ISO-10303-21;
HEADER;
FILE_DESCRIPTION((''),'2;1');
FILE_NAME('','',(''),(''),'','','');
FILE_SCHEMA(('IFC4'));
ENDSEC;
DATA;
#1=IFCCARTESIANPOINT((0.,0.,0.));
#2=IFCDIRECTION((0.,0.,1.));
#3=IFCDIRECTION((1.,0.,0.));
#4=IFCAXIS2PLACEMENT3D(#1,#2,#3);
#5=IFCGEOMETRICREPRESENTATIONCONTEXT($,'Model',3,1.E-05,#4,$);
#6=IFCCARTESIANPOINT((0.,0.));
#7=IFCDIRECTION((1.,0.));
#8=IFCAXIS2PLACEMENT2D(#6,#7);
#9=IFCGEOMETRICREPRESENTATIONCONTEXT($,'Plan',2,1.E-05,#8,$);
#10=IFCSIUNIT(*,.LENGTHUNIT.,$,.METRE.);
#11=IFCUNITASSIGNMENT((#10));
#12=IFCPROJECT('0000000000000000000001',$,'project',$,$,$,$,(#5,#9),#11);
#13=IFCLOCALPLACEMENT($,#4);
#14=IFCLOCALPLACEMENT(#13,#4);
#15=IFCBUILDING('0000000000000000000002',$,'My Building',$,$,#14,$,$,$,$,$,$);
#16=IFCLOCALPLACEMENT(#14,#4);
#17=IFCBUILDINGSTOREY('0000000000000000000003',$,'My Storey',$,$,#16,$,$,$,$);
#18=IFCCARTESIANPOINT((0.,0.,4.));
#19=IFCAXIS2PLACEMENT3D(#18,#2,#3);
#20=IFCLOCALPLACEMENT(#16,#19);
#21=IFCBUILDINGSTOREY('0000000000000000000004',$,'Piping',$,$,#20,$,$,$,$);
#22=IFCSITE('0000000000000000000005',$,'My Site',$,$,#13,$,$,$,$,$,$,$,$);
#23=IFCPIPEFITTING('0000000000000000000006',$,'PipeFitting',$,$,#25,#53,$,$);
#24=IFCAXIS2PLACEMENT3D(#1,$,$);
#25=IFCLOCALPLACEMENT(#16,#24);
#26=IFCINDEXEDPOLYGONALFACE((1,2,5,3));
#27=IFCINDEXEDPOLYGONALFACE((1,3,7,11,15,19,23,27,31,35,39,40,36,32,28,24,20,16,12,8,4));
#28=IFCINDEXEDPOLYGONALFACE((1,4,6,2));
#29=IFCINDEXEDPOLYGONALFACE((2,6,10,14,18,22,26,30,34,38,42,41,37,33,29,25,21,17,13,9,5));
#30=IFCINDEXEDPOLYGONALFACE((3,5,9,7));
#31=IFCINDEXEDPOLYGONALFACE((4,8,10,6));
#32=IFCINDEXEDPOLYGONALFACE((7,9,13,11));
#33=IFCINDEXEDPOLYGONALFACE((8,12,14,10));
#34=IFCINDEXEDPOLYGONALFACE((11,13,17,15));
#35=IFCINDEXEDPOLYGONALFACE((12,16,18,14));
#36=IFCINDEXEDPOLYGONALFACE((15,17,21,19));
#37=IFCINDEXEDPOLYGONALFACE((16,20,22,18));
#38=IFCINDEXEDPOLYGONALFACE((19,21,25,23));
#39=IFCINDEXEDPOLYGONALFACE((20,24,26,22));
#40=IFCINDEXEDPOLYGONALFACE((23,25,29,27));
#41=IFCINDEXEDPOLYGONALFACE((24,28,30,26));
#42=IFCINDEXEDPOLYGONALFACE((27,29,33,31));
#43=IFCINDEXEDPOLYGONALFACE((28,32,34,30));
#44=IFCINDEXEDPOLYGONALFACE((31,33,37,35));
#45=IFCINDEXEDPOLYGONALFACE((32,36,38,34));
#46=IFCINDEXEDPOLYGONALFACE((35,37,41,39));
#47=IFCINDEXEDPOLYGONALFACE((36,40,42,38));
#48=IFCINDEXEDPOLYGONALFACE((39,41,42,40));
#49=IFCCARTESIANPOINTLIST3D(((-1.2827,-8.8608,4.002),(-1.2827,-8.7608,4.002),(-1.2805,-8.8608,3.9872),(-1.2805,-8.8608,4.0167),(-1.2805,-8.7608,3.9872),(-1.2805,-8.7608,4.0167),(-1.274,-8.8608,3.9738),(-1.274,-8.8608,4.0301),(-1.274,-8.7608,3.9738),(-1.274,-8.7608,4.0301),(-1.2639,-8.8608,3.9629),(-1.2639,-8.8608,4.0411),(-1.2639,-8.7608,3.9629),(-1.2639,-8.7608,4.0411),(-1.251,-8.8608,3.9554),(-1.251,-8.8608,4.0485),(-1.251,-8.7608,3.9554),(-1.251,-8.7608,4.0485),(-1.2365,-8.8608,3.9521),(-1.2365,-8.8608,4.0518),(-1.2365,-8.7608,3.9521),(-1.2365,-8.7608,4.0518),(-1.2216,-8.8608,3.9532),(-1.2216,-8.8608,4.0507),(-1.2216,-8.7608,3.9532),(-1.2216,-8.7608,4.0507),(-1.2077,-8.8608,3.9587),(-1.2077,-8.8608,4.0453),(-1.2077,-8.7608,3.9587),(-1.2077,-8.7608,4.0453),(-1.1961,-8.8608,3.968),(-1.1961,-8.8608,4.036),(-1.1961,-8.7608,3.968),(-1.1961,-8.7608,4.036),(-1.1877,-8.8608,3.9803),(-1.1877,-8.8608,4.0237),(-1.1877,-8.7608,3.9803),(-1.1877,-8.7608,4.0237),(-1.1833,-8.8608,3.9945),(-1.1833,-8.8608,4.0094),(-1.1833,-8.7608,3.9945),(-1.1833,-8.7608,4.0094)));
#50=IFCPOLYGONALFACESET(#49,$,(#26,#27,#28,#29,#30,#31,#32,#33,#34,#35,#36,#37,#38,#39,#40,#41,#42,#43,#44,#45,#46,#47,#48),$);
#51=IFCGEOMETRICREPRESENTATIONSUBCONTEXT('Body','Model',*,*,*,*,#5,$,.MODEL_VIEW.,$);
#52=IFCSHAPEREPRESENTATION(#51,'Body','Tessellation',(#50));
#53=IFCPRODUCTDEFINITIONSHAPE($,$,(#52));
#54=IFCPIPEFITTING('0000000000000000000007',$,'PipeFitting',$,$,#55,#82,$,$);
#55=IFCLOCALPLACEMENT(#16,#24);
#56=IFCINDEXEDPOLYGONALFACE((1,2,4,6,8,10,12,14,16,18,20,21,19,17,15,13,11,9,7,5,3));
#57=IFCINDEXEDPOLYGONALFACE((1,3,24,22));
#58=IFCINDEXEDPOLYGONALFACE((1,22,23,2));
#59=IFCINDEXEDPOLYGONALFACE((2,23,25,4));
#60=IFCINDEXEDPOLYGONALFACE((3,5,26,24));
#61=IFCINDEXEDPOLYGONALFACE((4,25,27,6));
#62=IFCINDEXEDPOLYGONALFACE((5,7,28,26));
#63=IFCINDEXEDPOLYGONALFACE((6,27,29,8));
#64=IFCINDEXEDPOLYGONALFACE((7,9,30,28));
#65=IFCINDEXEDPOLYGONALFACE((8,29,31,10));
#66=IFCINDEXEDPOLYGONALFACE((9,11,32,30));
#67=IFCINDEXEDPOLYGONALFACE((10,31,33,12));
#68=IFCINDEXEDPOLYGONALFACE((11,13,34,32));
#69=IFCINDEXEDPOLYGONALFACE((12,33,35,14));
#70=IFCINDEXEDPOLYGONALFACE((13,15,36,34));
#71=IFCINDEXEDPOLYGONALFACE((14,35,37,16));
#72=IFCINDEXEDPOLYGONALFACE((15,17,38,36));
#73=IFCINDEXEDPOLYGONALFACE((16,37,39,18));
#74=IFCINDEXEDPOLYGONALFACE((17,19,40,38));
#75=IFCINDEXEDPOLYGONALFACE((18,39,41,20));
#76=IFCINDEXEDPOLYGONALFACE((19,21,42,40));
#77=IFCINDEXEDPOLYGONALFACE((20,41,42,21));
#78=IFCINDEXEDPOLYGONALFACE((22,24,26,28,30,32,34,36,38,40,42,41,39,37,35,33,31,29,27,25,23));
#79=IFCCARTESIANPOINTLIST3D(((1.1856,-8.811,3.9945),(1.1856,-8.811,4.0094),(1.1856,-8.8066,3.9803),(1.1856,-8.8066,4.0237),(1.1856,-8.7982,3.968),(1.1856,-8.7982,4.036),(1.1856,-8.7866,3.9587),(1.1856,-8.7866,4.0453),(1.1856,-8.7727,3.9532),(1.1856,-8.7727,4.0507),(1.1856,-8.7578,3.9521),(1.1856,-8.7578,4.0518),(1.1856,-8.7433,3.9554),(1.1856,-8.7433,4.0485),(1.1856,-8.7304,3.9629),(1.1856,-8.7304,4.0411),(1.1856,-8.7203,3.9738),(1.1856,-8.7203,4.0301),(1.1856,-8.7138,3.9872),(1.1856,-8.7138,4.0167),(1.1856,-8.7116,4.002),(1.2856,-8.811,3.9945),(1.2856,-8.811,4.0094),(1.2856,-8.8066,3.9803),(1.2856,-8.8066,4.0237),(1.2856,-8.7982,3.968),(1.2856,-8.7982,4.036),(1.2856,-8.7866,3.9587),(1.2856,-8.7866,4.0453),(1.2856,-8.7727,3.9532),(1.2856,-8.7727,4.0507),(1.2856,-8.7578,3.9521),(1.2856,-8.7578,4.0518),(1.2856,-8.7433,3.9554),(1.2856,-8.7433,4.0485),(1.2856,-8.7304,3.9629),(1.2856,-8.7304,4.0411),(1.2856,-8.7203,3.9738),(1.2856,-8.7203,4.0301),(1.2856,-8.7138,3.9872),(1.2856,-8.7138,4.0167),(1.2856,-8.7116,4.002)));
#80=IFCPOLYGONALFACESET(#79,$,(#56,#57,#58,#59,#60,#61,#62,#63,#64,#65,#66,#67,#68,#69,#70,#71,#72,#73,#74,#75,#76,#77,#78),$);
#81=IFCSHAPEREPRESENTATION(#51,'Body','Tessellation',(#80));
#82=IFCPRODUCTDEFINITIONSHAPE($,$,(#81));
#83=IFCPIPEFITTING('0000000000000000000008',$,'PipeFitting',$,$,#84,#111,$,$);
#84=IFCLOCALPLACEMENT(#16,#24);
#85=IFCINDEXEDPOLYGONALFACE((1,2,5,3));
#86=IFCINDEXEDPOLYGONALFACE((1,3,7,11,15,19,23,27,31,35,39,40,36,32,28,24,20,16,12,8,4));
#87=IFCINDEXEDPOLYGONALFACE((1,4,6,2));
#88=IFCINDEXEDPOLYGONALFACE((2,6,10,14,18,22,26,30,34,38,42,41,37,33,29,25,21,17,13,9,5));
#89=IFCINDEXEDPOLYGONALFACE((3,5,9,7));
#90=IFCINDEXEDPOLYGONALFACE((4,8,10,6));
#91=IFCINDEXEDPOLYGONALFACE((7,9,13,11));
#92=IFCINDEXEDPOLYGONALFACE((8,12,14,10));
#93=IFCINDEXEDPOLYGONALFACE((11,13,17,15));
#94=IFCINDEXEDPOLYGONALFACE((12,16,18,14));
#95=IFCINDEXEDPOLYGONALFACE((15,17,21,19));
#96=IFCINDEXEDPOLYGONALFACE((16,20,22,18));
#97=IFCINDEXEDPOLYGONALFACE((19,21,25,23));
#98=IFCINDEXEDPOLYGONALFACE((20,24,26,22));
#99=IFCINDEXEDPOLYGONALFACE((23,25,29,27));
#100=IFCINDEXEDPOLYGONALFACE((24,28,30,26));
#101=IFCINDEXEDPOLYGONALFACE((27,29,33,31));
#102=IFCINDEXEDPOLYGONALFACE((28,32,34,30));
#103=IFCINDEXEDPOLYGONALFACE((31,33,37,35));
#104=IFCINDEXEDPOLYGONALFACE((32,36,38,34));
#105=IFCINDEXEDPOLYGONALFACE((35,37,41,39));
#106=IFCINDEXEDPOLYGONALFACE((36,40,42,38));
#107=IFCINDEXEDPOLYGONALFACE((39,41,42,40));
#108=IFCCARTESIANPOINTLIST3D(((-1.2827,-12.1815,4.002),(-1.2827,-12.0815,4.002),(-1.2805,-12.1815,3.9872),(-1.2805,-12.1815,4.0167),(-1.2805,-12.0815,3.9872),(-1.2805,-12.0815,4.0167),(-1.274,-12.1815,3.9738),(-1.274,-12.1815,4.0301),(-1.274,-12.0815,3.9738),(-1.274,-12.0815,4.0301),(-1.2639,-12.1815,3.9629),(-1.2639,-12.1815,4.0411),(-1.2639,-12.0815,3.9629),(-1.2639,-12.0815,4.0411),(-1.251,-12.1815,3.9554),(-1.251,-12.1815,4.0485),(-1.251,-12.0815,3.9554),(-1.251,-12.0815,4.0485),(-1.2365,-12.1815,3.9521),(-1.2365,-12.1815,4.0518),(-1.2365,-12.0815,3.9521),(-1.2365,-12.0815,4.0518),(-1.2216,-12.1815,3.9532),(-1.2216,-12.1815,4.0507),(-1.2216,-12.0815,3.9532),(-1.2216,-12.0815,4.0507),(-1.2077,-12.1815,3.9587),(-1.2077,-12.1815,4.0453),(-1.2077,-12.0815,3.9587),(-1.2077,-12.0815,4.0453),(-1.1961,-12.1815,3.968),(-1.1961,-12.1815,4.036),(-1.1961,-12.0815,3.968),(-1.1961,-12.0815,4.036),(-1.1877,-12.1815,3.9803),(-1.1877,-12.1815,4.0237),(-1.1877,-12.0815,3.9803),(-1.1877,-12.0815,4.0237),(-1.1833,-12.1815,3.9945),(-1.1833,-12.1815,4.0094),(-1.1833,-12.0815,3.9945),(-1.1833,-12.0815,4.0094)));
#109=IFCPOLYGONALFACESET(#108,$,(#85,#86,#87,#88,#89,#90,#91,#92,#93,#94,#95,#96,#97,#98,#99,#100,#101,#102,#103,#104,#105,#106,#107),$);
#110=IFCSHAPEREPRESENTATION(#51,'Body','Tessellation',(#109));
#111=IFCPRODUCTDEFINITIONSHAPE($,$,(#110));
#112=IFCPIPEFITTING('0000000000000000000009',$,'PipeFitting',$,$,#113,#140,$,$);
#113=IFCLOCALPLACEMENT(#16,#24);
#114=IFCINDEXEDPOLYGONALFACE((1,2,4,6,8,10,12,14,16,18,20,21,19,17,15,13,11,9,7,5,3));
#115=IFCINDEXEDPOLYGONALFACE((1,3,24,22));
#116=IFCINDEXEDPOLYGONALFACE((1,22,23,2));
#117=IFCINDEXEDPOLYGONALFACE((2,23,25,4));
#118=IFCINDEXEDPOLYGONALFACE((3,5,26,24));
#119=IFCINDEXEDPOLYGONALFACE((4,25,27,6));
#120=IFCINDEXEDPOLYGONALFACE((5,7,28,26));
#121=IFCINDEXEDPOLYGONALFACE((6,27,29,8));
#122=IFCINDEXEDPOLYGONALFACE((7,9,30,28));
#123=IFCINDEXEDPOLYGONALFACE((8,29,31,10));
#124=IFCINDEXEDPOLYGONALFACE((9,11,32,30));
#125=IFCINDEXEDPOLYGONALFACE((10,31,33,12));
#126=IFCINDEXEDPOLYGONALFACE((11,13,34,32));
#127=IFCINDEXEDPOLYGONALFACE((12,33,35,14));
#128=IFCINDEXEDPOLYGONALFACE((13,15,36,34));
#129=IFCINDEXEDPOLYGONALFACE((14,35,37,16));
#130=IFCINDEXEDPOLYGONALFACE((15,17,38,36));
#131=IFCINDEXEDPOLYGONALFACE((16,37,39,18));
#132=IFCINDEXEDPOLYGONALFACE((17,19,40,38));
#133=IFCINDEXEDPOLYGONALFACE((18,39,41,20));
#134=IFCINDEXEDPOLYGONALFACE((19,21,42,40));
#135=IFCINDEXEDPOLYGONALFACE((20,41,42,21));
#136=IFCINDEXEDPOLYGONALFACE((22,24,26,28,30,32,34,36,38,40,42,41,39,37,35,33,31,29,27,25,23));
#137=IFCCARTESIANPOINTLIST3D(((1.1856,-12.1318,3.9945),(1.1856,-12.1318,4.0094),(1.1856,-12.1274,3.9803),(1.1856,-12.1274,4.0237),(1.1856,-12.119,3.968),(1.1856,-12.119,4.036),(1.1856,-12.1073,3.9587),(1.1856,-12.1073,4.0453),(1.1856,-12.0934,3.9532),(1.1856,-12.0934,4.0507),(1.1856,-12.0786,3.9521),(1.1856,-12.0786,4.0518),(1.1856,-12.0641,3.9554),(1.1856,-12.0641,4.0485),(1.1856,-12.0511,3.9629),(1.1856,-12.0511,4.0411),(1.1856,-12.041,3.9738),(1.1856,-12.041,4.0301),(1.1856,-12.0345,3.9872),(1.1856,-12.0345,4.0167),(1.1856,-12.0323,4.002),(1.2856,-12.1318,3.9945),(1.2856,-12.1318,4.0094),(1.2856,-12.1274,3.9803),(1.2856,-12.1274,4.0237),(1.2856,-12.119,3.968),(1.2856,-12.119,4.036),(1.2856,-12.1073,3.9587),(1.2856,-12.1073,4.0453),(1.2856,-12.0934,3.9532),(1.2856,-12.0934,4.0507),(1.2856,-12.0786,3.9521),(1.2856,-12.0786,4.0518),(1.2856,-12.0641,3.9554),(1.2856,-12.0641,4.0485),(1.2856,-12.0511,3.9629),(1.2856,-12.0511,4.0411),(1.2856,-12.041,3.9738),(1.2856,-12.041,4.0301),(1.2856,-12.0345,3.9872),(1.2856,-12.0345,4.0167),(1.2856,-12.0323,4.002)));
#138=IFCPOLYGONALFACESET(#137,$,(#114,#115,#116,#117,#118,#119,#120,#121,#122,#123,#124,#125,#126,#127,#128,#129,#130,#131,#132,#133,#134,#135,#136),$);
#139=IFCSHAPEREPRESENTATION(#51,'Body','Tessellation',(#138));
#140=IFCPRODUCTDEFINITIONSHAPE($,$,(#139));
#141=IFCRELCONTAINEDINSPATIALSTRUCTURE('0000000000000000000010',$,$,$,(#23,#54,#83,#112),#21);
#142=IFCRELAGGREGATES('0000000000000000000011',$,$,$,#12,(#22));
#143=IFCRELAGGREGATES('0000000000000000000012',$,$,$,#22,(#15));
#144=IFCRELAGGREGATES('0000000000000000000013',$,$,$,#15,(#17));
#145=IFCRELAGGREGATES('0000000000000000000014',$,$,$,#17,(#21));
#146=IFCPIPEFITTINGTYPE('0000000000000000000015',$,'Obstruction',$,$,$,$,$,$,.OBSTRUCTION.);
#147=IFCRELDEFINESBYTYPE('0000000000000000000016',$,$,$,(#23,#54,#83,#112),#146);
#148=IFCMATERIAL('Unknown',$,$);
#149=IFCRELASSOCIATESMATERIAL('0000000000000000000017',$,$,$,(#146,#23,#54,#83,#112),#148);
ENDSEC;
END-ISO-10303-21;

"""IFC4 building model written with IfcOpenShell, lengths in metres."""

from ifc_helpers import new_model, si_unit, frame, origin_with_axes, origin_2d_with_axis, place, context, subcontext, project, spatial, circle, extrude, material, material_profile, profile_set, profile_usage, type_object, element, save


model = new_model("IFC4")

# Units and contexts
model_context = context("Model", 3, precision=1e-05, world=origin_with_axes())
plan_context = context("Plan", 2, precision=1e-05, world=origin_2d_with_axis())
body_context = subcontext(model_context, "Body", "Model", "MODEL_VIEW")
ifc_project = project(units=[si_unit("LENGTHUNIT", "METRE")], contexts=[model_context, plan_context])

# Site, building, storeys
site_placement = place(None, origin_with_axes())
site = spatial("IfcSite", under=ifc_project, at=site_placement, Name="My Site")
building_placement = place(site_placement, origin_with_axes())
building = spatial("IfcBuilding", under=site, at=building_placement, Name="My Building")
storey_1_placement = place(building_placement, origin_with_axes())
storey_1 = spatial("IfcBuildingStorey", under=building, at=storey_1_placement, Name="My Storey")
storey_2_placement = place(storey_1_placement, frame((0.0, 0.0, 4.0), z_axis=(0.0, 0.0, 1.0), x_axis=(1.0, 0.0, 0.0)))
storey_2 = spatial("IfcBuildingStorey", under=storey_1, at=storey_2_placement, Name="Piping")

# Shared definitions
ifc_material = material(Name="Unknown")

# Pipe fittings
ifc_material_profile_1 = material_profile(ifc_material, circle(Radius=0.05))
ifc_profile_set_1 = profile_set([ifc_material_profile_1])
pipe_fitting_type_1 = type_object("IfcPipeFittingType", Name="Obstruction", PredefinedType="OBSTRUCTION", material=ifc_profile_set_1)
ifc_profile_usage_1 = profile_usage(ifc_profile_set_1, cardinal=5)
pipe_fitting_1_placement = place(storey_2_placement, frame((-1.2327, -8.8608, 0.002), z_axis=(0.0, 1.0, 0.000001), x_axis=(-1.0, 0.0, 0.0)))
element("IfcPipeFitting", 1, at=pipe_fitting_1_placement, inside=storey_2, type_object=pipe_fitting_type_1, material=ifc_profile_usage_1, Name="PipeFitting", context=body_context, shape_type="SweptSolid", body=[
    extrude(circle(Radius=0.05), origin_with_axes(), (0.0, 0.0, 1.0), 0.1),
])
ifc_profile_usage_2 = profile_usage(ifc_profile_set_1, cardinal=5)
pipe_fitting_2_placement = place(storey_2_placement, frame((1.1856, -8.7616, 0.002), z_axis=(1.0, 0.0, 0.0), x_axis=(0.0, 1.0, 0.0)))
element("IfcPipeFitting", 2, at=pipe_fitting_2_placement, inside=storey_2, type_object=pipe_fitting_type_1, material=ifc_profile_usage_2, Name="PipeFitting", context=body_context, shape_type="SweptSolid", body=[
    extrude(circle(Radius=0.05), origin_with_axes(), (0.0, 0.0, 1.0), 0.1),
])
ifc_profile_usage_3 = profile_usage(ifc_profile_set_1, cardinal=5)
pipe_fitting_3_placement = place(storey_2_placement, frame((-1.2327, -12.1815, 0.002), z_axis=(0.0, 1.0, 0.000001), x_axis=(-1.0, 0.0, 0.0)))
element("IfcPipeFitting", 3, at=pipe_fitting_3_placement, inside=storey_2, type_object=pipe_fitting_type_1, material=ifc_profile_usage_3, Name="PipeFitting", context=body_context, shape_type="SweptSolid", body=[
    extrude(circle(Radius=0.05), origin_with_axes(), (0.0, 0.0, 1.0), 0.1),
])
ifc_profile_usage_4 = profile_usage(ifc_profile_set_1, cardinal=5)
pipe_fitting_4_placement = place(storey_2_placement, frame((1.1856, -12.0823, 0.002), z_axis=(1.0, 0.0, 0.0), x_axis=(0.0, 1.0, 0.0)))
element("IfcPipeFitting", 4, at=pipe_fitting_4_placement, inside=storey_2, type_object=pipe_fitting_type_1, material=ifc_profile_usage_4, Name="PipeFitting", context=body_context, shape_type="SweptSolid", body=[
    extrude(circle(Radius=0.05), origin_with_axes(), (0.0, 0.0, 1.0), 0.1),
])

save(model, "model.ifc")
